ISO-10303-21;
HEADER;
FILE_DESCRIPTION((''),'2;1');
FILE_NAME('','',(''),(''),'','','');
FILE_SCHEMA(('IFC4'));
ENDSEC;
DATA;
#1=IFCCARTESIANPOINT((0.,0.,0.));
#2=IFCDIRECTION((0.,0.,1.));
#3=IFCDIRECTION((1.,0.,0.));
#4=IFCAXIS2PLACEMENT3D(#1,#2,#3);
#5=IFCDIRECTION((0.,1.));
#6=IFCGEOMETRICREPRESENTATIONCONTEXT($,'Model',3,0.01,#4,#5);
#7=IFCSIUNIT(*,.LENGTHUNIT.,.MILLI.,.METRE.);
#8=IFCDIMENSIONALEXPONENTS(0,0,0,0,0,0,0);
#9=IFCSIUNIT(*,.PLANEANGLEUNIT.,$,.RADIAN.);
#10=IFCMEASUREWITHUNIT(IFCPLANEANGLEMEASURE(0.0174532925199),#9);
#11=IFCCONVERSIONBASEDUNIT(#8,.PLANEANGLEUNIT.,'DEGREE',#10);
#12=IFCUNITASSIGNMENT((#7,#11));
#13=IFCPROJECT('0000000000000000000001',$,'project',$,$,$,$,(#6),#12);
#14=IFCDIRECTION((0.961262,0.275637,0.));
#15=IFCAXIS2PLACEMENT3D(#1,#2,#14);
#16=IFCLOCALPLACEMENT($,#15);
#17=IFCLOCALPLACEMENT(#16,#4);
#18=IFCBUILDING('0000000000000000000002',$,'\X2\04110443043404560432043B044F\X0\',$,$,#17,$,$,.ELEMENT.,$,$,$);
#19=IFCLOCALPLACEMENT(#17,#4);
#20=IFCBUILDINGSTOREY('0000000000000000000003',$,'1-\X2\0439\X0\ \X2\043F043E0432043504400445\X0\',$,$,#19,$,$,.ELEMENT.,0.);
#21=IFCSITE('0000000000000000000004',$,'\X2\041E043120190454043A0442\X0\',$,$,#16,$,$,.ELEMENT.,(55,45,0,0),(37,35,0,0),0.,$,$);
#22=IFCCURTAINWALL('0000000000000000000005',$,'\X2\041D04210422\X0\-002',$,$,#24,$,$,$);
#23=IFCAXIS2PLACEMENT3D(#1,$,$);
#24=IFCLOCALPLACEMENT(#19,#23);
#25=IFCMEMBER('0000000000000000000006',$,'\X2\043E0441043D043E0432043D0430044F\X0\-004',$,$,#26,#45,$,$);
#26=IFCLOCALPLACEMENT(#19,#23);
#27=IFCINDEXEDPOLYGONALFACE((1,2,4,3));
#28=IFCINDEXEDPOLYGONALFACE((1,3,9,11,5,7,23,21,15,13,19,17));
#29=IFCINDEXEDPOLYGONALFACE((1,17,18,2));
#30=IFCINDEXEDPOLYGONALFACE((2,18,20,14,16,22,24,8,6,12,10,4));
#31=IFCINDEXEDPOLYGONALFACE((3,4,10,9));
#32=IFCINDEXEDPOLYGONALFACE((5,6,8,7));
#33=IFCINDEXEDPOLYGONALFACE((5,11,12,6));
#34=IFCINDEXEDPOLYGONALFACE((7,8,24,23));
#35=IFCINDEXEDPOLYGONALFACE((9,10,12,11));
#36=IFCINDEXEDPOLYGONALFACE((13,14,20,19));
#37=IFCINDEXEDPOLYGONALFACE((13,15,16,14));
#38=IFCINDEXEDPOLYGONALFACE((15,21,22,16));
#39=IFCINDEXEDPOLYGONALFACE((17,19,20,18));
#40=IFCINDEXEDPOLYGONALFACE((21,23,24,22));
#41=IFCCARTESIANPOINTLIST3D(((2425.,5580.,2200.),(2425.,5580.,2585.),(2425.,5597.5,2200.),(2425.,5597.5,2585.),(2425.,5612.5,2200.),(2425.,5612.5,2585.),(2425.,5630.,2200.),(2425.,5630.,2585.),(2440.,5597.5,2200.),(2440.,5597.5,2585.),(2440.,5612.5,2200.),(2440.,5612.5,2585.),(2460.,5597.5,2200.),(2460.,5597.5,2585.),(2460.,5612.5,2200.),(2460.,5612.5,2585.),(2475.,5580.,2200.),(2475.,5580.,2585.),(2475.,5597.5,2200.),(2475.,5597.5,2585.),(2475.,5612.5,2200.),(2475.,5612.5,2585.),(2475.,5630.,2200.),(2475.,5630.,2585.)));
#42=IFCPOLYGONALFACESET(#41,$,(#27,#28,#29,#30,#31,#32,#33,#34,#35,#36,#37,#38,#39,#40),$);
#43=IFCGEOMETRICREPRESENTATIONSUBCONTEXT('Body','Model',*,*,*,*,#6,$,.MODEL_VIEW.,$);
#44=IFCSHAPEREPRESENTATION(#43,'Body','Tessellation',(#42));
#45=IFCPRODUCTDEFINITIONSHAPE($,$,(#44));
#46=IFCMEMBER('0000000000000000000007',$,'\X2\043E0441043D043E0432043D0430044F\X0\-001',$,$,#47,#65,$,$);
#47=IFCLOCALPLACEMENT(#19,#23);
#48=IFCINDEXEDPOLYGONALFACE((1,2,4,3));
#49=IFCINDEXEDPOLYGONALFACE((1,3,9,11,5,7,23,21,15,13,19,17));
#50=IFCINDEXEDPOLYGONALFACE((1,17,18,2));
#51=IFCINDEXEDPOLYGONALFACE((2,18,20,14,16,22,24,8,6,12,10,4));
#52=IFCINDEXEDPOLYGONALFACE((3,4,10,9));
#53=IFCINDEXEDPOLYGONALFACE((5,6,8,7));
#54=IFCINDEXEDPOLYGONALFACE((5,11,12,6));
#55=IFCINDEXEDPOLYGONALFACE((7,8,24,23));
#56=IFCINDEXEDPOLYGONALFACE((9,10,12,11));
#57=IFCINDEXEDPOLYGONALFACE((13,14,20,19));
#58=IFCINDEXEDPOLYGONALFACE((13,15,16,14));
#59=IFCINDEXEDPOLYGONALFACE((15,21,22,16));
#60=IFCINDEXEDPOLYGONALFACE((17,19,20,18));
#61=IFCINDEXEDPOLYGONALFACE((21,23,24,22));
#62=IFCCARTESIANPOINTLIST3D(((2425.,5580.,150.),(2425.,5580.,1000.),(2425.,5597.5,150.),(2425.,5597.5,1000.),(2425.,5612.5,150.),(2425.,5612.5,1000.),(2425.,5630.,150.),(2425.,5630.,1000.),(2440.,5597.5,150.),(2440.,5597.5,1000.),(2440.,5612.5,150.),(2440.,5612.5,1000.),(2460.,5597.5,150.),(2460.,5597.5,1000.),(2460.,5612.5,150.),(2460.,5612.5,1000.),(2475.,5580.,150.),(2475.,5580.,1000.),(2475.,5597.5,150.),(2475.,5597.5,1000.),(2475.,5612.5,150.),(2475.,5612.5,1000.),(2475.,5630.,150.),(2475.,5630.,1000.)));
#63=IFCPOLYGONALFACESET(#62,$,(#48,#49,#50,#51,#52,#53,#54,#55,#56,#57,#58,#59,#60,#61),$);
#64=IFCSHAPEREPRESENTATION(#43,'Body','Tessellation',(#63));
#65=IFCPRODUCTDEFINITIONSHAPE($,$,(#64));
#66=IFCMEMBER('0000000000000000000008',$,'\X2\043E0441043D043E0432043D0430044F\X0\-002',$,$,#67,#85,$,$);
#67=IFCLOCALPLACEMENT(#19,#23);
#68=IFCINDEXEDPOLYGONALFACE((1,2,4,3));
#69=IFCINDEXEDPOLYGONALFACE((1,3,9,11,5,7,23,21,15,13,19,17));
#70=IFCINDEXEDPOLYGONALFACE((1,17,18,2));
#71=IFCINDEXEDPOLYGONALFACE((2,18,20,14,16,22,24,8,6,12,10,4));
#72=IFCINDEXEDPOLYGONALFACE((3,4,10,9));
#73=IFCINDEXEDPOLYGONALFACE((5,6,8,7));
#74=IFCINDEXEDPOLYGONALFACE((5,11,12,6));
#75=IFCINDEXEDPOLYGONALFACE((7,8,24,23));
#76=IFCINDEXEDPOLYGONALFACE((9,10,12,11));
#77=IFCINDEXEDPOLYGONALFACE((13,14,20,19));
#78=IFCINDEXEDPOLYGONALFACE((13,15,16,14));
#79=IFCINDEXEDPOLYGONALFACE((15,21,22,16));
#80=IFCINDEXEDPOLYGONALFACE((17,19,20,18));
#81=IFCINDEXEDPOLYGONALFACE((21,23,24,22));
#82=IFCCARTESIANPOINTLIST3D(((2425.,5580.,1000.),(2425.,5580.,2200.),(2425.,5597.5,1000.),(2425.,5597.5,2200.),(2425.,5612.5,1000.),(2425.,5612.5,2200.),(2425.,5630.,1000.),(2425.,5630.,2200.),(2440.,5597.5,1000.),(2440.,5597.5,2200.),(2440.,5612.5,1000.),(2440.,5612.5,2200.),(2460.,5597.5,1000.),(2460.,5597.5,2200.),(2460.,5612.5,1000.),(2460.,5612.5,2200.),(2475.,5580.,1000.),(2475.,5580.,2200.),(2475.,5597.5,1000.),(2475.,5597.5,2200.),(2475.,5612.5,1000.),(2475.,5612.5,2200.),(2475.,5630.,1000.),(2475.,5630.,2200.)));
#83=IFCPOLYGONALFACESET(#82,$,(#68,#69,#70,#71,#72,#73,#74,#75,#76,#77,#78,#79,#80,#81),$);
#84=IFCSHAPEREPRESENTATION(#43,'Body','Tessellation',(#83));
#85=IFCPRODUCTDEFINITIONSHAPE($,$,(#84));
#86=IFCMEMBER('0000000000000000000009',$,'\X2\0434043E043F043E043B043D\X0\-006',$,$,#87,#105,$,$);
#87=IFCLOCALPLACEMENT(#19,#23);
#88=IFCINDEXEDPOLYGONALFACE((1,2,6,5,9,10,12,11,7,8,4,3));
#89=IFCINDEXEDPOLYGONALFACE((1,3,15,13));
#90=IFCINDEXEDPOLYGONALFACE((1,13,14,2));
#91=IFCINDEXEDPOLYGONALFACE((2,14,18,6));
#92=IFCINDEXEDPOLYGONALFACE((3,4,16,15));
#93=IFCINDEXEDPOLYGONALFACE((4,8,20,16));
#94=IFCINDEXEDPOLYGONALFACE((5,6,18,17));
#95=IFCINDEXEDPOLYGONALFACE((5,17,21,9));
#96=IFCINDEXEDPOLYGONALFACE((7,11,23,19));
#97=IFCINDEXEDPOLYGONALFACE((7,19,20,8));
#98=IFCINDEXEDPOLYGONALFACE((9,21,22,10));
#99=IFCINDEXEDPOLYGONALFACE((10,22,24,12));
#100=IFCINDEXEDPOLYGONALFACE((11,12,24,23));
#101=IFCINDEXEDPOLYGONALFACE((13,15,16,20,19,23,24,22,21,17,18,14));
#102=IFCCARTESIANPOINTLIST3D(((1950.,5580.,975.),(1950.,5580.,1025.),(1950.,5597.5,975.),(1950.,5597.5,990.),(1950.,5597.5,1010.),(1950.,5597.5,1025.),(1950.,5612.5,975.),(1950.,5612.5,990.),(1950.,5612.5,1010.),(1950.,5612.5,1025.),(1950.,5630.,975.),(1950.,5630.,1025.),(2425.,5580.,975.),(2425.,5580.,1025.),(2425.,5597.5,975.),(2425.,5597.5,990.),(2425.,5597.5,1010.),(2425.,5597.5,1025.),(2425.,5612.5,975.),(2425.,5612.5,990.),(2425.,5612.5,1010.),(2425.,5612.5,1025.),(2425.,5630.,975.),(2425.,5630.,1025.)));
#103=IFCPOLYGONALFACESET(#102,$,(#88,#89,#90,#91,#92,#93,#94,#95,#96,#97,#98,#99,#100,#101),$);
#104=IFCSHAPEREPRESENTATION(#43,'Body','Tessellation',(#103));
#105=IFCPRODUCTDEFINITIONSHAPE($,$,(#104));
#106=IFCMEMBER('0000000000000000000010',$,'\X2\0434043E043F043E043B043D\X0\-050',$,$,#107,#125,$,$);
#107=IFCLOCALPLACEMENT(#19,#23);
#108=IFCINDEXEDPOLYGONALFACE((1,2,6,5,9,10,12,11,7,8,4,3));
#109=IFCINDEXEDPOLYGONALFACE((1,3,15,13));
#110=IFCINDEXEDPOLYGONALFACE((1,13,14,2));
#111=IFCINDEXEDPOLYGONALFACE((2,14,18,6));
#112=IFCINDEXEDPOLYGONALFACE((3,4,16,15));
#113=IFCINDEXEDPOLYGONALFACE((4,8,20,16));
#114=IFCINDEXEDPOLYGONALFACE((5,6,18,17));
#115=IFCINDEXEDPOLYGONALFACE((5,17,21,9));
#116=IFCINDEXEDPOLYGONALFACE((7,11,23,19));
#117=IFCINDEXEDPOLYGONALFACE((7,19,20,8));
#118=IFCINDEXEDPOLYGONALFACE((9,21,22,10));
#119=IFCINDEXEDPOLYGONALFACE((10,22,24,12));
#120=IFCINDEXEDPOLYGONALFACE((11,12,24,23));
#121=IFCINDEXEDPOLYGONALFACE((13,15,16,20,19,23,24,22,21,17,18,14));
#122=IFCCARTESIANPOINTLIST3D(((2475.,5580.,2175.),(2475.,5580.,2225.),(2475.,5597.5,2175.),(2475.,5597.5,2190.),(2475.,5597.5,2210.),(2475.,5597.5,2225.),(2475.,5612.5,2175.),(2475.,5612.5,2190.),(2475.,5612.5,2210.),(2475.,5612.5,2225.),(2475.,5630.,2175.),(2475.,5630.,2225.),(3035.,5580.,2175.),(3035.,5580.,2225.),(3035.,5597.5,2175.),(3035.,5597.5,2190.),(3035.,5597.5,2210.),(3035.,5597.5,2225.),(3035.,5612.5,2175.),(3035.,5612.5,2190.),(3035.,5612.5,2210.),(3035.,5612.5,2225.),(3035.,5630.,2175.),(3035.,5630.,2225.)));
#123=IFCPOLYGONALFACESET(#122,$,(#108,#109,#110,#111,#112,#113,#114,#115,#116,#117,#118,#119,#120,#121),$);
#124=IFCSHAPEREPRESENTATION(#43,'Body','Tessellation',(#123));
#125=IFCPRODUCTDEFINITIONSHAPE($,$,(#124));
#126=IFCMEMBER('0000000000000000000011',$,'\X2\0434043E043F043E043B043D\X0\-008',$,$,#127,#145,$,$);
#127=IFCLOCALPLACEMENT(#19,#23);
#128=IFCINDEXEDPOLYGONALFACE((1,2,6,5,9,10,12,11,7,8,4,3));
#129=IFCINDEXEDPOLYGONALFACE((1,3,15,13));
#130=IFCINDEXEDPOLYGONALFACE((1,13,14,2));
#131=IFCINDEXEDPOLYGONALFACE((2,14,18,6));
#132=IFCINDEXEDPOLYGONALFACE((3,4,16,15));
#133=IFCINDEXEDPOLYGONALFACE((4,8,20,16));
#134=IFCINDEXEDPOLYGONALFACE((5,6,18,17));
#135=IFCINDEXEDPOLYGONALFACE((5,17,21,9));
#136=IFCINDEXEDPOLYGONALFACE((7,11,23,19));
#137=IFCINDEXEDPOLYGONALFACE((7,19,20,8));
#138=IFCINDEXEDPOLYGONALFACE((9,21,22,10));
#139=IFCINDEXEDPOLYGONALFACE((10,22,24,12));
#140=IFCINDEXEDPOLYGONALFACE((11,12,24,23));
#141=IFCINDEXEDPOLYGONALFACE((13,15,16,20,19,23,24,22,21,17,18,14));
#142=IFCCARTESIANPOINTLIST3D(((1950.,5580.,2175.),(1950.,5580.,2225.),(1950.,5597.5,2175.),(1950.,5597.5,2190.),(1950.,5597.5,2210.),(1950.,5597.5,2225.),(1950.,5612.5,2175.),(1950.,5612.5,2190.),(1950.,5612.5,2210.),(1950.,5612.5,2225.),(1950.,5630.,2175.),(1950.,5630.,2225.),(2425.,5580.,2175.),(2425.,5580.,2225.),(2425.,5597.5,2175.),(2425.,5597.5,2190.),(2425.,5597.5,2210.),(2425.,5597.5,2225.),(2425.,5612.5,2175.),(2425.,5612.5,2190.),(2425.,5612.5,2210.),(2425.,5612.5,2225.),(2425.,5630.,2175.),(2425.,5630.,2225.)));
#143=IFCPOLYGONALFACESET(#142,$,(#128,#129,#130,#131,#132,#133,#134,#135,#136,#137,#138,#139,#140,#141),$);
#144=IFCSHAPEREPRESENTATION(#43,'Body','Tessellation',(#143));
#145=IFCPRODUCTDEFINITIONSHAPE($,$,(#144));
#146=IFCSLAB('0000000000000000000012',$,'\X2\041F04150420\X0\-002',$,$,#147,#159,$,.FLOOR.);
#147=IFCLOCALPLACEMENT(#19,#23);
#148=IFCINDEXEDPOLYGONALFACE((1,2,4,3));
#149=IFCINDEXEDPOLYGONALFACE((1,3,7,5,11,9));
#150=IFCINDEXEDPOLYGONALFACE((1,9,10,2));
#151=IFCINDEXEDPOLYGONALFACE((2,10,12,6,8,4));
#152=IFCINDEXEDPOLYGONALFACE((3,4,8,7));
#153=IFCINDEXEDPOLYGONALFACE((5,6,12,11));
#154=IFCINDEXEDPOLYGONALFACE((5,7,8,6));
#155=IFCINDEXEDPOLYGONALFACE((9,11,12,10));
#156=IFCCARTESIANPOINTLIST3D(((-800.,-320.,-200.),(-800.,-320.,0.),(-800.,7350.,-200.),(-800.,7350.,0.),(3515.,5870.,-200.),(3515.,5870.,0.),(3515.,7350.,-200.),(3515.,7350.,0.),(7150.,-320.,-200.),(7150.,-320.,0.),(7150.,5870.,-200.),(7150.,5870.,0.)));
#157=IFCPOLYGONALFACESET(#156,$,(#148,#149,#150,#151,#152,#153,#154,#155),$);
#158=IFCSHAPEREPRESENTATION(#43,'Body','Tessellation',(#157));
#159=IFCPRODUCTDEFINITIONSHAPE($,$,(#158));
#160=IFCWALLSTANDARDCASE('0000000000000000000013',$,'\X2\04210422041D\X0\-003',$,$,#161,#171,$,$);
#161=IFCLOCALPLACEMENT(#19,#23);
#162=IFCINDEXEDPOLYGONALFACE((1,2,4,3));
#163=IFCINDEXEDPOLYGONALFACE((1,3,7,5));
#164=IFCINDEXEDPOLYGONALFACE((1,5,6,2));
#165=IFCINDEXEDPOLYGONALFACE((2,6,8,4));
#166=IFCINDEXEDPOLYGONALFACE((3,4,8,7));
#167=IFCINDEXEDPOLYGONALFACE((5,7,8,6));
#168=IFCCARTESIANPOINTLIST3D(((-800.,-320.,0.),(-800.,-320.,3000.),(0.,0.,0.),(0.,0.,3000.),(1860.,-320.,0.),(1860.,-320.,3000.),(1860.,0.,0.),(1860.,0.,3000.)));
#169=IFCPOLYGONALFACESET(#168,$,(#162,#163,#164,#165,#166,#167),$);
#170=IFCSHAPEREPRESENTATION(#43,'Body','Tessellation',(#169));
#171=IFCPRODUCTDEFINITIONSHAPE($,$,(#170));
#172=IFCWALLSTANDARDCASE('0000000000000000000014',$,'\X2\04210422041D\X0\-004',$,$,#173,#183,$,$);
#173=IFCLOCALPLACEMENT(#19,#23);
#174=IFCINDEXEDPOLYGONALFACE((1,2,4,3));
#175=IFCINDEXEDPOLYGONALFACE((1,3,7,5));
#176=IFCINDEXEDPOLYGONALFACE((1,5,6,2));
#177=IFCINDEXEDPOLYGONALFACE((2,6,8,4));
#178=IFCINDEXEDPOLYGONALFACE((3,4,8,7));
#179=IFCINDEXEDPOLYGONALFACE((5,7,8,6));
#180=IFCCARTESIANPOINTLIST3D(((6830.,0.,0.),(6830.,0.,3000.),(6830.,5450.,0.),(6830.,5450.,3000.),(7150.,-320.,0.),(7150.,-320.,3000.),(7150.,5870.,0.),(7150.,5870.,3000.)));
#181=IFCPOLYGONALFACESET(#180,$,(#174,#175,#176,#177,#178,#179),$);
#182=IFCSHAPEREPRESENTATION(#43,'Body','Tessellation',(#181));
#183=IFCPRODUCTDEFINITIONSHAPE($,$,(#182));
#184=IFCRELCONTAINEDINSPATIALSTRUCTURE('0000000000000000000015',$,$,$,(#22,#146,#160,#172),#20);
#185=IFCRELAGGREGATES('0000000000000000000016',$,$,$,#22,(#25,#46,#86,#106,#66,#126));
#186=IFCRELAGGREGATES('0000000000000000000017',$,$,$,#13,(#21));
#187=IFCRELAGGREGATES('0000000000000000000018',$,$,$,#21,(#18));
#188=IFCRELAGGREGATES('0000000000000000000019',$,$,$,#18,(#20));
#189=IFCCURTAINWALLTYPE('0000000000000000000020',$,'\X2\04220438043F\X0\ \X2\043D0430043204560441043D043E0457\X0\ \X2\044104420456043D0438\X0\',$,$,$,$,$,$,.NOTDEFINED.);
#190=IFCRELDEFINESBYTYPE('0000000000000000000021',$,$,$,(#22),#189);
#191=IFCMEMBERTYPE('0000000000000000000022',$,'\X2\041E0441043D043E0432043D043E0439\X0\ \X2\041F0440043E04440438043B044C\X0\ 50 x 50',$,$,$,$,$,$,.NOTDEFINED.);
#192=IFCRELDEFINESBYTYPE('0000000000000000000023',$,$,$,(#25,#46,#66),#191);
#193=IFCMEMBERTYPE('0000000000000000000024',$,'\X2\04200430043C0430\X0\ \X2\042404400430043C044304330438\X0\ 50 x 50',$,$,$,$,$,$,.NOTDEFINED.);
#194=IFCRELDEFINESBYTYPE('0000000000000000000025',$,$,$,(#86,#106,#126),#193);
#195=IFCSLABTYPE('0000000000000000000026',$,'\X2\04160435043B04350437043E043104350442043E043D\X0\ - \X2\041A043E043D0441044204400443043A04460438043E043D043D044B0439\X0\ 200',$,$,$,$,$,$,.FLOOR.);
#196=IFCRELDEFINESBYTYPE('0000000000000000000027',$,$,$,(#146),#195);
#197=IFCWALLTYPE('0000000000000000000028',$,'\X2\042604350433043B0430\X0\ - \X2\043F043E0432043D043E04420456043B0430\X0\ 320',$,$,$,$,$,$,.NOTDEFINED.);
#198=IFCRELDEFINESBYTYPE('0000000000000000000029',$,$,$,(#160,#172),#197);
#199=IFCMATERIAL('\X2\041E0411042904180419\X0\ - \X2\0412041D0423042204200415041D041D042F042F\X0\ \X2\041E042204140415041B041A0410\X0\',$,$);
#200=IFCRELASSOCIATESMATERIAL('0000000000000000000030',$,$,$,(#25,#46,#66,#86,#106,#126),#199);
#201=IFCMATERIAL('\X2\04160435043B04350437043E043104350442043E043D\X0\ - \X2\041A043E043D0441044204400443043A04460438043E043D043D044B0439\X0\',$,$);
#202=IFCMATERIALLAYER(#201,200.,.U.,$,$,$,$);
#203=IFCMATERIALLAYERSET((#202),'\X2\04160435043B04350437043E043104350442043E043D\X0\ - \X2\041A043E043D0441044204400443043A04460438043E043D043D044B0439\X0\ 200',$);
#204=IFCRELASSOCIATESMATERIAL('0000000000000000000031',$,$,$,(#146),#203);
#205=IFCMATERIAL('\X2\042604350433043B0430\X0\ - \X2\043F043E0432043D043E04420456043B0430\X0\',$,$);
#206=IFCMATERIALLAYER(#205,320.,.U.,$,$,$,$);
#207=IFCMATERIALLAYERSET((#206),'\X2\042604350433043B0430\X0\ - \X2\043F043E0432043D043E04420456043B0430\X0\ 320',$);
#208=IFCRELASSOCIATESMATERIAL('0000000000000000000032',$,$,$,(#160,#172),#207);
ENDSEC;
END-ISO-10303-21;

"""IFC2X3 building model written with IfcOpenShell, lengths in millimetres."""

from ifc_helpers import new_model, entity, si_unit, converted_unit, direction, frame, origin_with_axes, place, context, subcontext, project, spatial, polyline, outline, extrude, material, layer, layer_set, layer_usage, type_object, element, aggregate, save


model = new_model("IFC2X3")

# Units and contexts
model_context = context("Model", 3, precision=0.01, world=origin_with_axes(), true_north=direction((0.0, 1.0)))
body_context = subcontext(model_context, "Body", "Model", "MODEL_VIEW")
ifc_project = project(units=[si_unit("LENGTHUNIT", "METRE", prefix="MILLI"), converted_unit("PLANEANGLEUNIT", "DEGREE", entity("IfcPlaneAngleMeasure", 0.0174532925199), si_unit("PLANEANGLEUNIT", "RADIAN"), dimensions=[0, 0, 0, 0, 0, 0, 0])], contexts=[model_context])

# Site, building, storey
site_placement = place(None, frame((0.0, 0.0, 0.0), z_axis=(0.0, 0.0, 1.0), x_axis=(0.961262, 0.275637, 0.0)))
site = spatial("IfcSite", under=ifc_project, at=site_placement, Name="Об’єкт", CompositionType="ELEMENT", RefLatitude=(55, 45, 0, 0), RefLongitude=(37, 35, 0, 0), RefElevation=0.0)
building_placement = place(site_placement, origin_with_axes())
building = spatial("IfcBuilding", under=site, at=building_placement, Name="Будівля", CompositionType="ELEMENT")
storey_placement = place(building_placement, origin_with_axes())
storey = spatial("IfcBuildingStorey", under=building, at=storey_placement, Name="1-й поверх", CompositionType="ELEMENT", Elevation=0.0)

# Curtain wall, members
curtain_wall_type = type_object("IfcCurtainWallType", Name="Тип навісної стіни", PredefinedType="NOTDEFINED")
curtain_wall_placement = place(storey_placement, frame((2175.0, 5605.0, 100.0), z_axis=(0.0, 0.0, 1.0), x_axis=(1.0, 0.0, 0.0)))
curtain_wall = element("IfcCurtainWall", 1, at=curtain_wall_placement, inside=storey, type_object=curtain_wall_type, Name="НСТ-002")
ifc_material_1 = material(Name="ОБЩИЙ - ВНУТРЕННЯЯ ОТДЕЛКА")
member_type_1 = type_object("IfcMemberType", Name="Основной Профиль 50 x 50", PredefinedType="NOTDEFINED")
member_1_placement = place(curtain_wall_placement, frame((275.0, 0.0, 2100.0), z_axis=(0.0, 0.0, 1.0), x_axis=(-1.0, 0.0, 0.0)))
member_1 = element("IfcMember", 2, at=member_1_placement, type_object=member_type_1, material=ifc_material_1, Name="основная-004", context=body_context, shape_type="SweptSolid", body=[
    extrude(outline(polyline([(10.0, 7.5), (25.0, 7.5), (25.0, 25.0), (-25.0, 25.0), (-25.0, 7.5), (-10.0, 7.5), (-10.0, -7.5), (-25.0, -7.5), (-25.0, -25.0), (25.0, -25.0), (25.0, -7.5), (10.0, -7.5), (10.0, 7.5)])), frame((0.0, 0.0, 0.0), z_axis=(0.0, 0.0, 1.0), x_axis=(-1.0, 0.0, 0.0)), (0.0, 0.0, 1.0), 385.0),
])
member_2_placement = place(curtain_wall_placement, frame((275.0, 0.0, 0.0), z_axis=(0.0, 0.0, 1.0), x_axis=(-1.0, 0.0, 0.0)))
member_2 = element("IfcMember", 3, at=member_2_placement, type_object=member_type_1, material=ifc_material_1, Name="основная-001", context=body_context, shape_type="SweptSolid", body=[
    extrude(outline(polyline([(10.0, 7.5), (25.0, 7.5), (25.0, 25.0), (-25.0, 25.0), (-25.0, 7.5), (-10.0, 7.5), (-10.0, -7.5), (-25.0, -7.5), (-25.0, -25.0), (25.0, -25.0), (25.0, -7.5), (10.0, -7.5), (10.0, 7.5)])), frame((0.0, 0.0, 50.0), z_axis=(0.0, 0.0, 1.0), x_axis=(-1.0, 0.0, 0.0)), (0.0, 0.0, 1.0), 850.0),
])
member_3_placement = place(curtain_wall_placement, frame((275.0, 0.0, 900.0), z_axis=(0.0, 0.0, 1.0), x_axis=(-1.0, 0.0, 0.0)))
member_3 = element("IfcMember", 4, at=member_3_placement, type_object=member_type_1, material=ifc_material_1, Name="основная-002", context=body_context, shape_type="SweptSolid", body=[
    extrude(outline(polyline([(10.0, 7.5), (25.0, 7.5), (25.0, 25.0), (-25.0, 25.0), (-25.0, 7.5), (-10.0, 7.5), (-10.0, -7.5), (-25.0, -7.5), (-25.0, -25.0), (25.0, -25.0), (25.0, -7.5), (10.0, -7.5), (10.0, 7.5)])), frame((0.0, 0.0, 0.0), z_axis=(0.0, 0.0, 1.0), x_axis=(-1.0, 0.0, 0.0)), (0.0, 0.0, 1.0), 1200.0),
])
member_type_2 = type_object("IfcMemberType", Name="Рама Фрамуги 50 x 50", PredefinedType="NOTDEFINED")
member_4_placement = place(curtain_wall_placement, frame((-275.0, 0.0, 900.0), z_axis=(1.0, 0.0, 0.0), x_axis=(0.0, 0.0, 1.0)))
member_4 = element("IfcMember", 5, at=member_4_placement, type_object=member_type_2, material=ifc_material_1, Name="дополн-006", context=body_context, shape_type="SweptSolid", body=[
    extrude(outline(polyline([(-7.5, 10.0), (-7.5, 25.0), (-25.0, 25.0), (-25.0, -25.0), (-7.5, -25.0), (-7.5, -10.0), (7.5, -10.0), (7.5, -25.0), (25.0, -25.0), (25.0, 25.0), (7.5, 25.0), (7.5, 10.0), (-7.5, 10.0)])), frame((0.0, 0.0, 50.0), z_axis=(0.0, 0.0, 1.0), x_axis=(0.0, 1.0, 0.0)), (0.0, 0.0, 1.0), 475.0),
])
member_5_placement = place(curtain_wall_placement, frame((275.0, 0.0, 2100.0), z_axis=(1.0, 0.0, 0.0), x_axis=(0.0, 0.0, 1.0)))
member_5 = element("IfcMember", 6, at=member_5_placement, type_object=member_type_2, material=ifc_material_1, Name="дополн-050", context=body_context, shape_type="SweptSolid", body=[
    extrude(outline(polyline([(-7.5, 10.0), (-7.5, 25.0), (-25.0, 25.0), (-25.0, -25.0), (-7.5, -25.0), (-7.5, -10.0), (7.5, -10.0), (7.5, -25.0), (25.0, -25.0), (25.0, 25.0), (7.5, 25.0), (7.5, 10.0), (-7.5, 10.0)])), frame((0.0, 0.0, 25.0), z_axis=(0.0, 0.0, 1.0), x_axis=(0.0, 1.0, 0.0)), (0.0, 0.0, 1.0), 560.0),
])
member_6_placement = place(curtain_wall_placement, frame((-275.0, 0.0, 2100.0), z_axis=(1.0, 0.0, 0.0), x_axis=(0.0, 0.0, 1.0)))
member_6 = element("IfcMember", 7, at=member_6_placement, type_object=member_type_2, material=ifc_material_1, Name="дополн-008", context=body_context, shape_type="SweptSolid", body=[
    extrude(outline(polyline([(-7.5, 10.0), (-7.5, 25.0), (-25.0, 25.0), (-25.0, -25.0), (-7.5, -25.0), (-7.5, -10.0), (7.5, -10.0), (7.5, -25.0), (25.0, -25.0), (25.0, 25.0), (7.5, 25.0), (7.5, 10.0), (-7.5, 10.0)])), frame((0.0, 0.0, 50.0), z_axis=(0.0, 0.0, 1.0), x_axis=(0.0, 1.0, 0.0)), (0.0, 0.0, 1.0), 475.0),
])

# Slab
ifc_material_2 = material(Name="Железобетон - Конструкционный")
ifc_layer_1 = layer(ifc_material_2, 200.0, ventilated="UNKNOWN")
ifc_layer_set_1 = layer_set([ifc_layer_1], Name="Железобетон - Конструкционный 200")
ifc_layer_usage_1 = layer_usage(ifc_layer_set_1, "AXIS3", "NEGATIVE", 200.0)
slab_type_1 = type_object("IfcSlabType", Name="Железобетон - Конструкционный 200", PredefinedType="FLOOR")
slab_1_placement = place(storey_placement, frame((7150.0, -320.0, 0.0), z_axis=(0.0, 0.0, 1.0), x_axis=(1.0, 0.0, 0.0)))
element("IfcSlab", 8, at=slab_1_placement, inside=storey, type_object=slab_type_1, material=ifc_layer_usage_1, Name="ПЕР-002", PredefinedType="FLOOR", context=body_context, shape_type="SweptSolid", body=[
    extrude(outline(polyline([(0.0, 0.0), (0.0, 6190.0), (-3635.0, 6190.0), (-3635.0, 7670.0), (-7950.0, 7670.0), (-7950.0, 0.0), (0.0, 0.0)])), frame((0.0, 0.0, -200.0), z_axis=(0.0, 0.0, 1.0), x_axis=(1.0, 0.0, 0.0)), (0.0, 0.0, 1.0), 200.0),
])

aggregate(curtain_wall, [member_1, member_2, member_4, member_5, member_3, member_6])

# Walls
ifc_material_3 = material(Name="Цегла - повнотіла")
ifc_layer_2 = layer(ifc_material_3, 320.0, ventilated="UNKNOWN")
ifc_layer_set_2 = layer_set([ifc_layer_2], Name="Цегла - повнотіла 320")
ifc_layer_usage_2 = layer_usage(ifc_layer_set_2, "AXIS2", "POSITIVE", 0.0)
wall_type_1 = type_object("IfcWallType", Name="Цегла - повнотіла 320", PredefinedType="NOTDEFINED")
wall_1_placement = place(storey_placement, frame((-800.0, -320.0, 0.0), z_axis=(0.0, 0.0, 1.0), x_axis=(1.0, 0.0, 0.0)))
element("IfcWallStandardCase", 9, at=wall_1_placement, inside=storey, type_object=wall_type_1, material=ifc_layer_usage_2, Name="СТН-003", context=body_context, shape_type="SweptSolid", body=[
    extrude(outline(polyline([(0.0, 0.0), (2660.0, 0.0), (2660.0, 320.0), (800.0, 320.0), (0.0, 0.0)])), origin_with_axes(), (0.0, 0.0, 1.0), 3000.0),
])
ifc_layer_usage_3 = layer_usage(ifc_layer_set_2, "AXIS2", "POSITIVE", 0.0)
wall_2_placement = place(storey_placement, frame((7150.0, -320.0, 0.0), z_axis=(0.0, 0.0, 1.0), x_axis=(0.0, 1.0, 0.0)))
element("IfcWallStandardCase", 10, at=wall_2_placement, inside=storey, type_object=wall_type_1, material=ifc_layer_usage_3, Name="СТН-004", context=body_context, shape_type="SweptSolid", body=[
    extrude(outline(polyline([(0.0, 0.0), (6190.0, 0.0), (5770.0, 320.0), (320.0, 320.0), (0.0, 0.0)])), origin_with_axes(), (0.0, 0.0, 1.0), 3000.0),
])

save(model, "model.ifc")
